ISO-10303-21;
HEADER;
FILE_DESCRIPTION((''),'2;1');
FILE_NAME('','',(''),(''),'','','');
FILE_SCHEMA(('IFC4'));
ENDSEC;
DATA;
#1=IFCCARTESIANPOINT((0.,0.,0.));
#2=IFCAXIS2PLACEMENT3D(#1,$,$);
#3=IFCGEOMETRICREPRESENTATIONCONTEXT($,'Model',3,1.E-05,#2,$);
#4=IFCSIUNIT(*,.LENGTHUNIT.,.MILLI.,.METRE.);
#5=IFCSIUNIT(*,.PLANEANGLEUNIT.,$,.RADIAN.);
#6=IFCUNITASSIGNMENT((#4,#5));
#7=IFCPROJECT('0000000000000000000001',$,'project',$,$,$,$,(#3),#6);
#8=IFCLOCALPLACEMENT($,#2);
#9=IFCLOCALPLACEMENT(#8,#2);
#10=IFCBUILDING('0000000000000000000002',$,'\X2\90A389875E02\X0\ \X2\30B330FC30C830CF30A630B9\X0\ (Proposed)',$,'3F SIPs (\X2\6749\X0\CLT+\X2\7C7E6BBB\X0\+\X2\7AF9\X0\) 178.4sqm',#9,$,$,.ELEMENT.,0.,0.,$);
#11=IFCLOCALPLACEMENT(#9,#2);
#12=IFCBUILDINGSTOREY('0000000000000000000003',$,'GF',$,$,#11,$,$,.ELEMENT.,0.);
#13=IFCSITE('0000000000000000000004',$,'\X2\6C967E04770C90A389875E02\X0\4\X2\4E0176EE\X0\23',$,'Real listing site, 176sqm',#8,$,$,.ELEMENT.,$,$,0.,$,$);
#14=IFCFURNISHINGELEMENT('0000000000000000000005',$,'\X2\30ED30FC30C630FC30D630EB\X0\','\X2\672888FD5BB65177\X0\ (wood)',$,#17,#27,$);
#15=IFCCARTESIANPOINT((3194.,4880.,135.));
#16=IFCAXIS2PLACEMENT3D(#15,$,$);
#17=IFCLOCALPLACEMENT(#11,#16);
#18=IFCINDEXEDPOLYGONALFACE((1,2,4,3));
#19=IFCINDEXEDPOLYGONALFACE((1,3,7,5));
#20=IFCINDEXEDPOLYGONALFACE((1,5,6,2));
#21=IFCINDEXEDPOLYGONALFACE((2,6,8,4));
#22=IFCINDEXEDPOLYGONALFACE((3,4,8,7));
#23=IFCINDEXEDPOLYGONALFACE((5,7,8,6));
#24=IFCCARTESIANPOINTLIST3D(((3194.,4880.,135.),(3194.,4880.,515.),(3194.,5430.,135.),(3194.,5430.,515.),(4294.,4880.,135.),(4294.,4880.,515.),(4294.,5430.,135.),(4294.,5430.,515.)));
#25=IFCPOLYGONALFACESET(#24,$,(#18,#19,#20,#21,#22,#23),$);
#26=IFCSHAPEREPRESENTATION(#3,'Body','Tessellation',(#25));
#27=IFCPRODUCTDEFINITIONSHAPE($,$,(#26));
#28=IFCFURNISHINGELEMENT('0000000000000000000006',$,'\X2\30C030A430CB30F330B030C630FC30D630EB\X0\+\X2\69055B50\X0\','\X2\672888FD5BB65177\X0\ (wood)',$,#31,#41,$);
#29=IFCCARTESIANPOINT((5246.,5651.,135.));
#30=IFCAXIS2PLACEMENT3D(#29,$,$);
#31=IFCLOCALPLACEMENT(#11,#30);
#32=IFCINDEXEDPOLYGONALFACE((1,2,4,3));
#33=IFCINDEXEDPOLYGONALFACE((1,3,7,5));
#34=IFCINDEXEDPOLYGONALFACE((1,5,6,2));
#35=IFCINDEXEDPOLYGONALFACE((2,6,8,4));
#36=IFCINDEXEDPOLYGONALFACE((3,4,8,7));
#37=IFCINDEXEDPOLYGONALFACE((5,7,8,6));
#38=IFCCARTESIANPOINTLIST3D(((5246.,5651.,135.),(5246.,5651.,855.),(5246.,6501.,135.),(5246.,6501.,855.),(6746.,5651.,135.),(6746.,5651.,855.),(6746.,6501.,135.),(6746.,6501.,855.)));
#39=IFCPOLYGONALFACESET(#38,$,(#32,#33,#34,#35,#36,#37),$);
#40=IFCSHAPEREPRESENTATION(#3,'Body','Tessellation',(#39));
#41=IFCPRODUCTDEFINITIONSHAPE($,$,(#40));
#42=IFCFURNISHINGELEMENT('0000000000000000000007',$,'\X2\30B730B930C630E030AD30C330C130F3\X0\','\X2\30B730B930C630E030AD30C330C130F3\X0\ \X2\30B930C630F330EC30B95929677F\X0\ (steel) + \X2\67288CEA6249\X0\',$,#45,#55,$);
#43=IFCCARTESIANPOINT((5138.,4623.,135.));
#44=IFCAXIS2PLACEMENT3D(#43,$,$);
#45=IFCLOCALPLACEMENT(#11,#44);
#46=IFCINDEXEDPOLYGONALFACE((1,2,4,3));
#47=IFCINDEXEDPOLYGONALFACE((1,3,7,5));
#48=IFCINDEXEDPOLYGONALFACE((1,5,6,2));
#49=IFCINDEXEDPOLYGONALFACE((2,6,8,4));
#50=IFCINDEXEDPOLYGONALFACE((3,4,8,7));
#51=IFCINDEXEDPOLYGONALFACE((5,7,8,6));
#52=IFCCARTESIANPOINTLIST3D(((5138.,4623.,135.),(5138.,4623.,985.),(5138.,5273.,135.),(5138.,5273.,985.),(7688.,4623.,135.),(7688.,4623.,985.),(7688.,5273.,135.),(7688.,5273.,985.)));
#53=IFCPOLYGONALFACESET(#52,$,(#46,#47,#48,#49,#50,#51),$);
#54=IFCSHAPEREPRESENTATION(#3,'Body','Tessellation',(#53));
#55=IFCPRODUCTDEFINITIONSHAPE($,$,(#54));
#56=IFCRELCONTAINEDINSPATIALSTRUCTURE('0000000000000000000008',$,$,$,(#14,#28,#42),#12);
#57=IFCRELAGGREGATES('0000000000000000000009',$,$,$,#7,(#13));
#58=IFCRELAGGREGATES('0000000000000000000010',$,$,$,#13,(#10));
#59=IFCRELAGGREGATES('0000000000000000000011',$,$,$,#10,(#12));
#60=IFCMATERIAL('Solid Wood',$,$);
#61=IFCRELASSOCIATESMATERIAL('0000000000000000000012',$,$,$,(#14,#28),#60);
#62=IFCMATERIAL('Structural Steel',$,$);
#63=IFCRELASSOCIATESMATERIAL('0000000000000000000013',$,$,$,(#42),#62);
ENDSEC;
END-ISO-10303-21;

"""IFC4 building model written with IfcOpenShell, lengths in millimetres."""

from ifc_helpers import new_model, si_unit, frame, frame_2d, origin, place, context, project, spatial, rectangle, extrude, material, element, save


model = new_model("IFC4")

# Units and contexts
model_context = context("Model", 3, precision=1e-05, world=origin())
ifc_project = project(units=[si_unit("LENGTHUNIT", "METRE", prefix="MILLI"), si_unit("PLANEANGLEUNIT", "RADIAN")], contexts=[model_context])

# Site, building, storey
site_placement = place(None, origin())
site = spatial("IfcSite", under=ifc_project, at=site_placement, Name="沖縄県那覇市4丁目23", ObjectType="Real listing site, 176sqm", CompositionType="ELEMENT", RefElevation=0.0)
building_placement = place(site_placement, origin())
building = spatial("IfcBuilding", under=site, at=building_placement, Name="那覇市 コートハウス (Proposed)", ObjectType="3F SIPs (杉CLT+籾殻+竹) 178.4sqm", CompositionType="ELEMENT", ElevationOfRefHeight=0.0, ElevationOfTerrain=0.0)
storey_placement = place(building_placement, origin())
storey = spatial("IfcBuildingStorey", under=building, at=storey_placement, Name="GF", CompositionType="ELEMENT", Elevation=0.0)

# Shared definitions
ifc_material_1 = material(Name="Solid Wood")

# Furnishing elements
furnishing_1_placement = place(storey_placement, frame((3194.0, 4880.0, 135.0)))
element("IfcFurnishingElement", 1, at=furnishing_1_placement, inside=storey, material=ifc_material_1, Name="ローテーブル", Description="木製家具 (wood)", context=model_context, shape_type="SweptSolid", body=[
    extrude(rectangle(XDim=1100.0, YDim=550.0, at=frame_2d((550.0, 275.0))), frame((3194.0, 4880.0, 135.0)), (0.0, 0.0, 1.0), 380.0),
])
furnishing_2_placement = place(storey_placement, frame((5246.0, 5651.0, 135.0)))
element("IfcFurnishingElement", 2, at=furnishing_2_placement, inside=storey, material=ifc_material_1, Name="ダイニングテーブル+椅子", Description="木製家具 (wood)", context=model_context, shape_type="SweptSolid", body=[
    extrude(rectangle(XDim=1500.0, YDim=850.0, at=frame_2d((750.0, 425.0))), frame((5246.0, 5651.0, 135.0)), (0.0, 0.0, 1.0), 720.0),
])
ifc_material_2 = material(Name="Structural Steel")
furnishing_3_placement = place(storey_placement, frame((5138.0, 4623.0, 135.0)))
element("IfcFurnishingElement", 3, at=furnishing_3_placement, inside=storey, material=ifc_material_2, Name="システムキッチン", Description="システムキッチン ステンレス天板 (steel) + 木質扉", context=model_context, shape_type="SweptSolid", body=[
    extrude(rectangle(XDim=2550.0, YDim=650.0, at=frame_2d((1275.0, 325.0))), frame((5138.0, 4623.0, 135.0)), (0.0, 0.0, 1.0), 850.0),
])

save(model, "model.ifc")
